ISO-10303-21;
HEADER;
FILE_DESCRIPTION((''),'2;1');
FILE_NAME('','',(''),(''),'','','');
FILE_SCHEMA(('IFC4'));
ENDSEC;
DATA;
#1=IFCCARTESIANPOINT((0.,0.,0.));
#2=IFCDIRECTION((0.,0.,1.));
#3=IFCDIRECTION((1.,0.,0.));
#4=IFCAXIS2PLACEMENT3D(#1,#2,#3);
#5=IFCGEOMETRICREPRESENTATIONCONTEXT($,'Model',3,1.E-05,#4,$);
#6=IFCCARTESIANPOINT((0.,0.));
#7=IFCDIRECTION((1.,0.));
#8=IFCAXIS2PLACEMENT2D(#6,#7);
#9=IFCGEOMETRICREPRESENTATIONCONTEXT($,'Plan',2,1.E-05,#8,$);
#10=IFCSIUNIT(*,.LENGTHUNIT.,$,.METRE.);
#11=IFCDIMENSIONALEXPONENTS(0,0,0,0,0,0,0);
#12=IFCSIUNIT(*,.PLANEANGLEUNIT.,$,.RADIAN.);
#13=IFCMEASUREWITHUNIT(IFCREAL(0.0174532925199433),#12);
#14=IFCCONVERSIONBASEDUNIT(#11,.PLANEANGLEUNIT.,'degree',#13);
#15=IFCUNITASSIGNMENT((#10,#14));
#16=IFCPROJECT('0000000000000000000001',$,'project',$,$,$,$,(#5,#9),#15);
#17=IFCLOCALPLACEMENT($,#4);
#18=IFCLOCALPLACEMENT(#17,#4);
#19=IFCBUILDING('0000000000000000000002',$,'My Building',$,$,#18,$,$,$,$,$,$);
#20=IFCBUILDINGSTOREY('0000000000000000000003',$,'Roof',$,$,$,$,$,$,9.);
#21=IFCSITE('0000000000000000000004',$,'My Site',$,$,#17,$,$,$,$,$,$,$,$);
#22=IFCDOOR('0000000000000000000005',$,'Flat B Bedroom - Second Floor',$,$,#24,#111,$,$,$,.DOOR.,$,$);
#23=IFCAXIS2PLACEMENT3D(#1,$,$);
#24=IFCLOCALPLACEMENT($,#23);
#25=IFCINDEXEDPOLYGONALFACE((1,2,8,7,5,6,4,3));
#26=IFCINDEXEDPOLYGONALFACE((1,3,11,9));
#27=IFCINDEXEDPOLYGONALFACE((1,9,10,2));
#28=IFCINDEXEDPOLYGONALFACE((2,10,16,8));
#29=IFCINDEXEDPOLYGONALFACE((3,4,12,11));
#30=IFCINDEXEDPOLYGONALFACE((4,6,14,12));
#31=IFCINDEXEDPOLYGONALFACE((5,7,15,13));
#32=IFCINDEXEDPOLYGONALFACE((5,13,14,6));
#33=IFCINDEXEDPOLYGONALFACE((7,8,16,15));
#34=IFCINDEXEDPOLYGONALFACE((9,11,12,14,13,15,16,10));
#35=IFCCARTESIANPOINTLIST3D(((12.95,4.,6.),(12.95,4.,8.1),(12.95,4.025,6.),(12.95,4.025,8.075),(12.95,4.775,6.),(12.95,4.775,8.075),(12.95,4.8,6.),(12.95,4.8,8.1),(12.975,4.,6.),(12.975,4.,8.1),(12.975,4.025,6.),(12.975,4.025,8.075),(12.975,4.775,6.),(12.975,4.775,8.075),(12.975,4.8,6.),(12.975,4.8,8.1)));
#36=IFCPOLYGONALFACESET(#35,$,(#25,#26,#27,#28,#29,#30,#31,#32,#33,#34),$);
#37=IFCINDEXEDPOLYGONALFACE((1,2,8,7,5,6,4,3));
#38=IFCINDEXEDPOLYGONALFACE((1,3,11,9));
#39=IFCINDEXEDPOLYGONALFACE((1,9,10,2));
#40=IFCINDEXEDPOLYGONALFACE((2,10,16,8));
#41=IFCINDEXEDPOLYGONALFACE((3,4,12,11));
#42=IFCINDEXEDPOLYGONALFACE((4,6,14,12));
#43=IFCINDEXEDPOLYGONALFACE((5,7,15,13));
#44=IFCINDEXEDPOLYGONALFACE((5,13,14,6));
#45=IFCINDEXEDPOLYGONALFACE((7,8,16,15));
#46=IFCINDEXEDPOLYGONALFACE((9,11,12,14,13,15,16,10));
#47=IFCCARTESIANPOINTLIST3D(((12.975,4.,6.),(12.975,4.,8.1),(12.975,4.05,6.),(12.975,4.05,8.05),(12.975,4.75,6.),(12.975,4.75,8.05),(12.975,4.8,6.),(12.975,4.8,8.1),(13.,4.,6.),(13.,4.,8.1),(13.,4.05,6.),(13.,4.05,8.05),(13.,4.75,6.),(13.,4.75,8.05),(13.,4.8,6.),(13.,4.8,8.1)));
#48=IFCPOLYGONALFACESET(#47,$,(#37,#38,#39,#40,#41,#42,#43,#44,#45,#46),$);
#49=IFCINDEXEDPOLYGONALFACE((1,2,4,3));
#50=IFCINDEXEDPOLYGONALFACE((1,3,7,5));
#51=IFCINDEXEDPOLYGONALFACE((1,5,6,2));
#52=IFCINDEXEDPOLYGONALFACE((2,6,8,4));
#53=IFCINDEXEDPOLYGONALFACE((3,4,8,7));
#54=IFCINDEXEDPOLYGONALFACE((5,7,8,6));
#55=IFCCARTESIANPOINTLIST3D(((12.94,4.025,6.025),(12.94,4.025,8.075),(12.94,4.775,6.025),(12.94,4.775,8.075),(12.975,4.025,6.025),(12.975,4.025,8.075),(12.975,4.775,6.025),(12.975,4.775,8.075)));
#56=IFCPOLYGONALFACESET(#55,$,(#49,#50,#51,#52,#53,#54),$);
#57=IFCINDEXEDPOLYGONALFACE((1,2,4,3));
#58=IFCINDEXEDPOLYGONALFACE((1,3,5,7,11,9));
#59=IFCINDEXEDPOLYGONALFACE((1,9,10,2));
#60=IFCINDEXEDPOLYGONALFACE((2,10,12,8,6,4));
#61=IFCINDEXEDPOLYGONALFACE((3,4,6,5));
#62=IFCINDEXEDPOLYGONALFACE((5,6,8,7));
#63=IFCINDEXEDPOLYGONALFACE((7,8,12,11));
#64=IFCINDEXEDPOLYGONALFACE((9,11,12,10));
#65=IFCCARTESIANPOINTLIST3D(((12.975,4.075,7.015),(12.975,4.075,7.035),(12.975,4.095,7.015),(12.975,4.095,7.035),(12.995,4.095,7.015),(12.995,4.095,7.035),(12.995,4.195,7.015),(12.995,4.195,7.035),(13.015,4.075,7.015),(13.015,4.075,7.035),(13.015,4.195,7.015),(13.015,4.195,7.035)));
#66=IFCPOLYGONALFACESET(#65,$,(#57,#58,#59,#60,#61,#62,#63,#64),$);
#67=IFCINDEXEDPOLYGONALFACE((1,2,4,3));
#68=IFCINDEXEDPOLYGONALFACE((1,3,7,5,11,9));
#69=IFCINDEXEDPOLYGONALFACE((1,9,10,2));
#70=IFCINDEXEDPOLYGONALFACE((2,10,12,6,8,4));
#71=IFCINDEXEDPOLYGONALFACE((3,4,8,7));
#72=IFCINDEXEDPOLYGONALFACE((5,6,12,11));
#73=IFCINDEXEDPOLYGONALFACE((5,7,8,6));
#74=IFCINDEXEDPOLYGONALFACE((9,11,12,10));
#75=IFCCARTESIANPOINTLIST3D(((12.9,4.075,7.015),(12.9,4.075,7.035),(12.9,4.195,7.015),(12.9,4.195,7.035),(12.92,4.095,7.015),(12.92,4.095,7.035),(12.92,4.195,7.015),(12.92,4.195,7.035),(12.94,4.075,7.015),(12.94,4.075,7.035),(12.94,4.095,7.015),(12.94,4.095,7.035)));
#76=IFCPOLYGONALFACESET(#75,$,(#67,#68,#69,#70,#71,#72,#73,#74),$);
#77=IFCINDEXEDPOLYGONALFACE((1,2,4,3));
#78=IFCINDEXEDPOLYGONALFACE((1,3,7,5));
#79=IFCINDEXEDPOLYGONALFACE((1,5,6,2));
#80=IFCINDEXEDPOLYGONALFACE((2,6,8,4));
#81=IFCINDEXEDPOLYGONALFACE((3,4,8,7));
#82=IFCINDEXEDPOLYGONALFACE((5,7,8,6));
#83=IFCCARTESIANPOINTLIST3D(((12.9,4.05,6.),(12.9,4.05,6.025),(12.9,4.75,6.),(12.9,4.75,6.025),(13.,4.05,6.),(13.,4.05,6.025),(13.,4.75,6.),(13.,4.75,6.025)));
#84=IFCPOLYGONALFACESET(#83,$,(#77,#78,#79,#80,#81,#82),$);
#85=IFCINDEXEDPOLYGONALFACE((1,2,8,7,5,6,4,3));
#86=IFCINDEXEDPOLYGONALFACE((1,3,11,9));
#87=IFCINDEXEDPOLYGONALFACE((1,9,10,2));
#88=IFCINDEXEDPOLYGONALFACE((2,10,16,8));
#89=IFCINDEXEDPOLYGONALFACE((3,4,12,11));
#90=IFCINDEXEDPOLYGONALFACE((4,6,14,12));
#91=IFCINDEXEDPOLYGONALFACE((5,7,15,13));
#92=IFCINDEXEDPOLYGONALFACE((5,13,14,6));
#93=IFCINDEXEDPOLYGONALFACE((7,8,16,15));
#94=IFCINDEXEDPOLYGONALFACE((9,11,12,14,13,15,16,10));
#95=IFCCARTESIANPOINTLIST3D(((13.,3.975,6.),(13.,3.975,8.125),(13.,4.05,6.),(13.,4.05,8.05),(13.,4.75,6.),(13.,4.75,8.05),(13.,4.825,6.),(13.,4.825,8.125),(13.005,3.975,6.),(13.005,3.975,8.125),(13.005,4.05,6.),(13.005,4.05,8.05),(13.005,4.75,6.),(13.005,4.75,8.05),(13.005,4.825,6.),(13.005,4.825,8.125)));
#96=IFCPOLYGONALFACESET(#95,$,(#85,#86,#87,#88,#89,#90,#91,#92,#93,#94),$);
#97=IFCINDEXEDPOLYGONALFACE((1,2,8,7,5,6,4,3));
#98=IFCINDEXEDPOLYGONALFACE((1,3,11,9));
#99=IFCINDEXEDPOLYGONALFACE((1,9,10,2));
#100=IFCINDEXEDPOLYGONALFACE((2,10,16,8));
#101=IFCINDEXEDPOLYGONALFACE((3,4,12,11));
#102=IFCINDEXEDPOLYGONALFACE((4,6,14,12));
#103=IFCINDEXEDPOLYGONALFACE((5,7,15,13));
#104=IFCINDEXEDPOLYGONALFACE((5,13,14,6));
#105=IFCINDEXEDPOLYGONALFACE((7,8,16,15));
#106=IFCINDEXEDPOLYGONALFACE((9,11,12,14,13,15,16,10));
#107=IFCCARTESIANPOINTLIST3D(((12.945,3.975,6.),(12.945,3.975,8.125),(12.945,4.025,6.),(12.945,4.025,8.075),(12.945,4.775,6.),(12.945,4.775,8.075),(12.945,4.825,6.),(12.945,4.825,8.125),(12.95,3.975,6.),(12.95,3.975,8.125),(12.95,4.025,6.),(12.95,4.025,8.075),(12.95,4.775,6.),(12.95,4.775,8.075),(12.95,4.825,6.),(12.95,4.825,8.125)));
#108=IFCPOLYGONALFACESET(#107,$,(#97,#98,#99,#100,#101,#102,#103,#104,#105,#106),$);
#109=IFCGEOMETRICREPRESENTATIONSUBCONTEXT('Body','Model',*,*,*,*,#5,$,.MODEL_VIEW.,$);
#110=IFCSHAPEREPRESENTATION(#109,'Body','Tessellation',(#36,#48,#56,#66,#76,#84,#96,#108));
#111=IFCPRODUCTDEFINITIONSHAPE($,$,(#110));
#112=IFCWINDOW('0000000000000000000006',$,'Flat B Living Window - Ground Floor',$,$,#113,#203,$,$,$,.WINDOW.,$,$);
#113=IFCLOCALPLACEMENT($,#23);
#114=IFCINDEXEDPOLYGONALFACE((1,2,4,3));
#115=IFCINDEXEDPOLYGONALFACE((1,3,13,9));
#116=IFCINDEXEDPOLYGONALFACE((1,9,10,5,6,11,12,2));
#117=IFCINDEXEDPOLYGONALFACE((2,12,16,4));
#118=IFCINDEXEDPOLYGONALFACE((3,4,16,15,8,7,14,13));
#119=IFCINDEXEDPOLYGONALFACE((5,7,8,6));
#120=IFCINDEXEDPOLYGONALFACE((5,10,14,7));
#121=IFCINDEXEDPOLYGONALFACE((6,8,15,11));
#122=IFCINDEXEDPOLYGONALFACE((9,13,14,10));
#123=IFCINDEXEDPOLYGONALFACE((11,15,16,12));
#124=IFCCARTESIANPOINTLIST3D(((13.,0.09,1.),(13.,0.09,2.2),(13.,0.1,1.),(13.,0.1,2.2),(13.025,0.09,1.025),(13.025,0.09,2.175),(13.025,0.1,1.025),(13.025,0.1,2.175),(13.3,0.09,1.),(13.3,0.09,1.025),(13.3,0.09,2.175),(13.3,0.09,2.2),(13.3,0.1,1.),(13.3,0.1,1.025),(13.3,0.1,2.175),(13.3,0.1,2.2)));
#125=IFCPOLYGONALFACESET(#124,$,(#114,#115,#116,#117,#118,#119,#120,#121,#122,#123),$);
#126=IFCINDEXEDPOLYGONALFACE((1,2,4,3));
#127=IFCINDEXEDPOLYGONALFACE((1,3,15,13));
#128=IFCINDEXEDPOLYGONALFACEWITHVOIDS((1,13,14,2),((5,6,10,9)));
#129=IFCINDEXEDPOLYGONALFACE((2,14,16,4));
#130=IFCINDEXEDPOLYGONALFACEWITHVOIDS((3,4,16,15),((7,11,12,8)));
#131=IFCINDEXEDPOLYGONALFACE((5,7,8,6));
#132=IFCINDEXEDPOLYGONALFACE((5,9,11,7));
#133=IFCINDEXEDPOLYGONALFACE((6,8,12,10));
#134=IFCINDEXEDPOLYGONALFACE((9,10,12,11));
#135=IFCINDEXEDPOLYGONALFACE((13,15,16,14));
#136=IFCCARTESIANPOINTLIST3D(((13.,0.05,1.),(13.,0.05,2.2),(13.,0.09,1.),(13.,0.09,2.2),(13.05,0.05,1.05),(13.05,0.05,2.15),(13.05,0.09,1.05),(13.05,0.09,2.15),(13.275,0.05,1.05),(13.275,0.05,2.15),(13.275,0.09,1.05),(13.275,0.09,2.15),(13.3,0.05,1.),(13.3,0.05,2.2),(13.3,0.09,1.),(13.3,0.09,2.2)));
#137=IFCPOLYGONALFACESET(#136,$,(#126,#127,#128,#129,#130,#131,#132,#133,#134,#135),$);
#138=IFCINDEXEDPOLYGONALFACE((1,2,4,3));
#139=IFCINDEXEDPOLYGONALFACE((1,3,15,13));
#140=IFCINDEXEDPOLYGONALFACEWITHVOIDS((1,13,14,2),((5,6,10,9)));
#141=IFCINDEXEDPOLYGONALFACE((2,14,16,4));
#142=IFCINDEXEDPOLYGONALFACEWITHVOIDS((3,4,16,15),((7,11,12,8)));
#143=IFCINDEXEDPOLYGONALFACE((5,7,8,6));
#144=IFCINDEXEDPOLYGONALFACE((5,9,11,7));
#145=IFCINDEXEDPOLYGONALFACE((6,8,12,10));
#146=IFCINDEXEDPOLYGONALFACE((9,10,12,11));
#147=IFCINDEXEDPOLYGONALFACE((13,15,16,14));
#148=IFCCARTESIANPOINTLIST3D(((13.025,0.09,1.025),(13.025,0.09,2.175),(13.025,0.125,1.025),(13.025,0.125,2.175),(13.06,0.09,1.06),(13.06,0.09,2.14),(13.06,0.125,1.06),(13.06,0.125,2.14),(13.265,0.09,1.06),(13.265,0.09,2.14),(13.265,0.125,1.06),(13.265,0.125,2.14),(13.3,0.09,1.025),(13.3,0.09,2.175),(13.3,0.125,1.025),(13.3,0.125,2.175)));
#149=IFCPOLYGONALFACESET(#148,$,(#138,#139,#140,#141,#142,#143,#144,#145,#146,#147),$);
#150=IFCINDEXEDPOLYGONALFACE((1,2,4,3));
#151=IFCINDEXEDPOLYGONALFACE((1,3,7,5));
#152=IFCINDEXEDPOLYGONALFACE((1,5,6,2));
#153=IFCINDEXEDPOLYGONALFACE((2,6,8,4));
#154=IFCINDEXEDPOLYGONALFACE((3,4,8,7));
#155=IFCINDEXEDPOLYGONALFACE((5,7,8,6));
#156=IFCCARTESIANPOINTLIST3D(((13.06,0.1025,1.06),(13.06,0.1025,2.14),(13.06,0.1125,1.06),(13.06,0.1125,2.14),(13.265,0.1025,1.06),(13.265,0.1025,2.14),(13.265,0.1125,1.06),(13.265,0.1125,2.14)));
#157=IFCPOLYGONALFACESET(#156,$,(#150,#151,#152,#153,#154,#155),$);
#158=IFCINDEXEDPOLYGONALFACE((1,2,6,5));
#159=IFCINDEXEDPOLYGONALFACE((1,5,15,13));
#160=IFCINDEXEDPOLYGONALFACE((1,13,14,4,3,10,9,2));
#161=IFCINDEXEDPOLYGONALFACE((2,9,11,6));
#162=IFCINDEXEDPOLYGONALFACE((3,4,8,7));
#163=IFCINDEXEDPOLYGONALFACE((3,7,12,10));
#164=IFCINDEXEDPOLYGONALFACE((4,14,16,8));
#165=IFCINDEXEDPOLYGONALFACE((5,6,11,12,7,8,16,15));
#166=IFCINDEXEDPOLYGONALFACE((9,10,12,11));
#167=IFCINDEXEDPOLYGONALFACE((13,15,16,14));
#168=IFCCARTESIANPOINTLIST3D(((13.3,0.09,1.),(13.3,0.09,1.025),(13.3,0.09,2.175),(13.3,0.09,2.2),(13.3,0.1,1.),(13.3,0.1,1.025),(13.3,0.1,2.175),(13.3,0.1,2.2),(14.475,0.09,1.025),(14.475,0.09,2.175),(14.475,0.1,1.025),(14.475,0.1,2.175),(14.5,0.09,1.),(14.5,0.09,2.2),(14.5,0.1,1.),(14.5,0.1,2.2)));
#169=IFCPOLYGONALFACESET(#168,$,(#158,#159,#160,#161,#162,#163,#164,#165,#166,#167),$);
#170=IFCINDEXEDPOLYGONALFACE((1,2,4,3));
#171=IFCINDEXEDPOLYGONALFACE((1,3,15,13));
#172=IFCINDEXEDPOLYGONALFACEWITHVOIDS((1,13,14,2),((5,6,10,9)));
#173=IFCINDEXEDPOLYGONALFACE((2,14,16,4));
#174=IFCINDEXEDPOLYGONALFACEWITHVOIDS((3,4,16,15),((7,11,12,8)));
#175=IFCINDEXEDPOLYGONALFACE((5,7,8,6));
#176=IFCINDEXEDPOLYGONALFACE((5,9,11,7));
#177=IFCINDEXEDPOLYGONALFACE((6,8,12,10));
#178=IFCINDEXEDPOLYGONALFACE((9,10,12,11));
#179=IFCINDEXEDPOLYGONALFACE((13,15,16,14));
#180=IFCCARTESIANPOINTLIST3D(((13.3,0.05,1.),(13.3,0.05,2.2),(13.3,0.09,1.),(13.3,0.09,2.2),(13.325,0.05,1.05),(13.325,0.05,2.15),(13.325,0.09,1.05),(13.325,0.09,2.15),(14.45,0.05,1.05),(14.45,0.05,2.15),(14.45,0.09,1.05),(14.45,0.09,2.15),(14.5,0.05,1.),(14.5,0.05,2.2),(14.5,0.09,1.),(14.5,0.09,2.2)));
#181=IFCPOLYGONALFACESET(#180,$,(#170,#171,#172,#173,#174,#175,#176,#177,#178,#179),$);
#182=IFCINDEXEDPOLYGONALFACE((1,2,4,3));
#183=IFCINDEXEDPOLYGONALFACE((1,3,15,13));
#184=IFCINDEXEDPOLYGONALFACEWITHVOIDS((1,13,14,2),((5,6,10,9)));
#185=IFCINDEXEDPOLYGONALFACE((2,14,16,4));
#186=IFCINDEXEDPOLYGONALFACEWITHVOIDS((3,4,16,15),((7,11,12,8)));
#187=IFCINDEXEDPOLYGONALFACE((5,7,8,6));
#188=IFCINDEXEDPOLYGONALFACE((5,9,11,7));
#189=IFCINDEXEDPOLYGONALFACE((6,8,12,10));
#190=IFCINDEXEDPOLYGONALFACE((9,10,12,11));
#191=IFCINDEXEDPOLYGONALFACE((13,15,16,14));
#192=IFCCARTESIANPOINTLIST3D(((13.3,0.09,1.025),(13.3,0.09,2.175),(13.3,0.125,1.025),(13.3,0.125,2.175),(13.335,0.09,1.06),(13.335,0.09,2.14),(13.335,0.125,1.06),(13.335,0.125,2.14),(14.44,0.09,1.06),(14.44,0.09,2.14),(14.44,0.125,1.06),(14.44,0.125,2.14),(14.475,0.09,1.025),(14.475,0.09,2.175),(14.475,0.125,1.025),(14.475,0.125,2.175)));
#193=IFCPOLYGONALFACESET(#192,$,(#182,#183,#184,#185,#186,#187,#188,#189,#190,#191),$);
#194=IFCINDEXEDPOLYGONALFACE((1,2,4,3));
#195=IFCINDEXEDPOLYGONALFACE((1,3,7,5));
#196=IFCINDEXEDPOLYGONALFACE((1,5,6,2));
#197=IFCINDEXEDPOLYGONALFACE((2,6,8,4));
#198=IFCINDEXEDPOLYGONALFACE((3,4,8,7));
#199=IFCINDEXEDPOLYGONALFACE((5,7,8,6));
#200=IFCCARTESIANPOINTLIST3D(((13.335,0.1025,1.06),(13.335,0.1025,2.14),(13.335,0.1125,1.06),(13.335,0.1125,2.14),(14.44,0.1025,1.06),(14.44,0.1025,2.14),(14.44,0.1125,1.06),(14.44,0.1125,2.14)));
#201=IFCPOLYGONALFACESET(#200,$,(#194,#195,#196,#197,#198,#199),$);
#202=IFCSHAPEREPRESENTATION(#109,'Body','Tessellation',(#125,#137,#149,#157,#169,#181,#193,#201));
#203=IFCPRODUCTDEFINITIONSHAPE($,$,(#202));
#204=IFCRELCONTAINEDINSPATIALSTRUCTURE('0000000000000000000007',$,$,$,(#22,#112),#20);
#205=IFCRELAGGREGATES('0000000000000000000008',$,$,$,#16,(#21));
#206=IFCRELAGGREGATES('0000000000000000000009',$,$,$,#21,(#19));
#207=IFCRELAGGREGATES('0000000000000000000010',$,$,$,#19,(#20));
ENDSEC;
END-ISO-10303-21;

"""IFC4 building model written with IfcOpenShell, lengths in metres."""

from ifc_helpers import new_model, entity, si_unit, converted_unit, frame, origin_with_axes, origin_2d_with_axis, place, context, subcontext, project, spatial, line, indexed_curve, outline, extrude, element, save


model = new_model("IFC4")

# Units and contexts
model_context = context("Model", 3, precision=1e-05, world=origin_with_axes())
plan_context = context("Plan", 2, precision=1e-05, world=origin_2d_with_axis())
body_context = subcontext(model_context, "Body", "Model", "MODEL_VIEW")
ifc_project = project(units=[si_unit("LENGTHUNIT", "METRE"), converted_unit("PLANEANGLEUNIT", "degree", entity("IfcReal", 0.0174532925199433), si_unit("PLANEANGLEUNIT", "RADIAN"), dimensions=[0, 0, 0, 0, 0, 0, 0])], contexts=[model_context, plan_context])

# Site, building, storey
site_placement = place(None, origin_with_axes())
site = spatial("IfcSite", under=ifc_project, at=site_placement, Name="My Site")
building_placement = place(site_placement, origin_with_axes())
building = spatial("IfcBuilding", under=site, at=building_placement, Name="My Building")
storey = spatial("IfcBuildingStorey", under=building, Name="Roof", Elevation=9.0)

# Door
door_1_placement = place(None, frame((13.0, 4.0, 6.0), z_axis=(0.0, 0.0, 1.0), x_axis=(0.0, 1.0, 0.0)))
element("IfcDoor", 1, at=door_1_placement, inside=storey, Name="Flat B Bedroom - Second Floor", PredefinedType="DOOR", context=body_context, shape_type="SweptSolid", body=[
    extrude(outline(indexed_curve([(0.0, 0.0), (0.0, 2.1), (0.8, 2.1), (0.8, 0.0), (0.775, 0.0), (0.775, 2.075), (0.025, 2.075), (0.025, 0.0)], segments=[line(1, 2, 3, 4, 5, 6, 7, 8, 1)])), frame((0.0, 0.025, 0.0), z_axis=(0.0, -1.0, 0.0), x_axis=(1.0, 0.0, 0.0)), (0.0, 0.0, -1.0), 0.025),
    extrude(outline(indexed_curve([(0.0, 0.0), (0.0, 2.1), (0.8, 2.1), (0.8, 0.0), (0.75, 0.0), (0.75, 2.05), (0.05, 2.05), (0.05, 0.0)], segments=[line(1, 2, 3, 4, 5, 6, 7, 8, 1)])), frame((0.0, 0.0, 0.0), z_axis=(0.0, -1.0, 0.0), x_axis=(1.0, 0.0, 0.0)), (0.0, 0.0, -1.0), 0.025),
    extrude(outline(indexed_curve([(0.0, 0.0), (0.75, 0.0), (0.75, 0.035), (0.0, 0.035)], segments=[line(1, 2, 3, 4, 1)])), frame((0.025, 0.025, 0.025), z_axis=(0.0, 0.0, 1.0), x_axis=(1.0, 0.0, 0.0)), (0.0, 0.0, 1.0), 2.05),
    extrude(outline(indexed_curve([(0.0, 0.0), (0.0, -0.04), (0.12, -0.04), (0.12, -0.02), (0.02, -0.02), (0.02, 0.0)], segments=[line(1, 2, 3, 4, 5, 6, 1)])), frame((0.075, 0.025, 1.015), z_axis=(0.0, 0.0, 1.0), x_axis=(1.0, 0.0, 0.0)), (0.0, 0.0, 1.0), 0.02),
    extrude(outline(indexed_curve([(0.0, 0.0), (0.0, 0.04), (0.12, 0.04), (0.12, 0.02), (0.02, 0.02), (0.02, 0.0)], segments=[line(1, 2, 3, 4, 5, 6, 1)])), frame((0.075, 0.06, 1.015), z_axis=(0.0, 0.0, 1.0), x_axis=(1.0, 0.0, 0.0)), (0.0, 0.0, 1.0), 0.02),
    extrude(outline(indexed_curve([(0.0, 0.0), (0.7, 0.0), (0.7, 0.1), (0.0, 0.1)], segments=[line(1, 2, 3, 4, 1)])), frame((0.05, 0.0, 0.0), z_axis=(0.0, 0.0, 1.0), x_axis=(1.0, 0.0, 0.0)), (0.0, 0.0, 1.0), 0.025),
    extrude(outline(indexed_curve([(0.0, 0.0), (0.0, 2.125), (0.85, 2.125), (0.85, 0.0), (0.775, 0.0), (0.775, 2.05), (0.075, 2.05), (0.075, 0.0)], segments=[line(1, 2, 3, 4, 5, 6, 7, 8, 1)])), frame((-0.025, -0.005, 0.0), z_axis=(0.0, -1.0, 0.0), x_axis=(1.0, 0.0, 0.0)), (0.0, 0.0, -1.0), 0.005),
    extrude(outline(indexed_curve([(0.0, 0.0), (0.0, 2.125), (0.85, 2.125), (0.85, 0.0), (0.8, 0.0), (0.8, 2.075), (0.05, 2.075), (0.05, 0.0)], segments=[line(1, 2, 3, 4, 5, 6, 7, 8, 1)])), frame((-0.025, 0.05, 0.0), z_axis=(0.0, -1.0, 0.0), x_axis=(1.0, 0.0, 0.0)), (0.0, 0.0, -1.0), 0.005),
])

# Window
window_1_placement = place(None, frame((13.0, 0.0, 1.0), z_axis=(0.0, 0.0, 1.0), x_axis=(1.0, 0.0, 0.0)))
element("IfcWindow", 2, at=window_1_placement, inside=storey, Name="Flat B Living Window - Ground Floor", PredefinedType="WINDOW", context=body_context, shape_type="SweptSolid", body=[
    extrude(outline(indexed_curve([(0.3, 0.0), (0.0, 0.0), (0.0, 1.2), (0.3, 1.2), (0.3, 1.175), (0.025, 1.175), (0.025, 0.025), (0.3, 0.025)], segments=[line(1, 2, 3, 4, 5, 6, 7, 8, 1)])), frame((0.0, 0.09, 0.0), z_axis=(0.0, -1.0, 0.0), x_axis=(1.0, 0.0, 0.0)), (0.0, 0.0, -1.0), 0.01),
    extrude(outline(indexed_curve([(0.0, 0.0), (0.3, 0.0), (0.3, 1.2), (0.0, 1.2)], segments=[line(1, 2, 3, 4, 1)]), holes=[indexed_curve([(0.05, 0.05), (0.275, 0.05), (0.275, 1.15), (0.05, 1.15)], segments=[line(1, 2, 3, 4, 1)])]), frame((0.0, 0.05, 0.0), z_axis=(0.0, -1.0, 0.0), x_axis=(1.0, 0.0, 0.0)), (0.0, 0.0, -1.0), 0.04),
    extrude(outline(indexed_curve([(0.0, 0.0), (0.275, 0.0), (0.275, 1.15), (0.0, 1.15)], segments=[line(1, 2, 3, 4, 1)]), holes=[indexed_curve([(0.035, 0.035), (0.24, 0.035), (0.24, 1.115), (0.035, 1.115)], segments=[line(1, 2, 3, 4, 1)])]), frame((0.025, 0.09, 0.025), z_axis=(0.0, -1.0, 0.0), x_axis=(1.0, 0.0, 0.0)), (0.0, 0.0, -1.0), 0.035),
    extrude(outline(indexed_curve([(0.035, 0.035), (0.24, 0.035), (0.24, 1.115), (0.035, 1.115)], segments=[line(1, 2, 3, 4, 1)])), frame((0.025, 0.1025, 0.025), z_axis=(0.0, -1.0, 0.0), x_axis=(1.0, 0.0, 0.0)), (0.0, 0.0, -1.0), 0.01),
    extrude(outline(indexed_curve([(0.0, 1.2), (1.2, 1.2), (1.2, 0.0), (0.0, 0.0), (0.0, 0.025), (1.175, 0.025), (1.175, 1.175), (0.0, 1.175)], segments=[line(1, 2, 3, 4, 5, 6, 7, 8, 1)])), frame((0.3, 0.09, 0.0), z_axis=(0.0, -1.0, 0.0), x_axis=(1.0, 0.0, 0.0)), (0.0, 0.0, -1.0), 0.01),
    extrude(outline(indexed_curve([(0.0, 0.0), (1.2, 0.0), (1.2, 1.2), (0.0, 1.2)], segments=[line(1, 2, 3, 4, 1)]), holes=[indexed_curve([(0.025, 0.05), (1.15, 0.05), (1.15, 1.15), (0.025, 1.15)], segments=[line(1, 2, 3, 4, 1)])]), frame((0.3, 0.05, 0.0), z_axis=(0.0, -1.0, 0.0), x_axis=(1.0, 0.0, 0.0)), (0.0, 0.0, -1.0), 0.04),
    extrude(outline(indexed_curve([(0.0, 0.0), (1.175, 0.0), (1.175, 1.15), (0.0, 1.15)], segments=[line(1, 2, 3, 4, 1)]), holes=[indexed_curve([(0.035, 0.035), (1.14, 0.035), (1.14, 1.115), (0.035, 1.115)], segments=[line(1, 2, 3, 4, 1)])]), frame((0.3, 0.09, 0.025), z_axis=(0.0, -1.0, 0.0), x_axis=(1.0, 0.0, 0.0)), (0.0, 0.0, -1.0), 0.035),
    extrude(outline(indexed_curve([(0.035, 0.035), (1.14, 0.035), (1.14, 1.115), (0.035, 1.115)], segments=[line(1, 2, 3, 4, 1)])), frame((0.3, 0.1025, 0.025), z_axis=(0.0, -1.0, 0.0), x_axis=(1.0, 0.0, 0.0)), (0.0, 0.0, -1.0), 0.01),
])

save(model, "model.ifc")
